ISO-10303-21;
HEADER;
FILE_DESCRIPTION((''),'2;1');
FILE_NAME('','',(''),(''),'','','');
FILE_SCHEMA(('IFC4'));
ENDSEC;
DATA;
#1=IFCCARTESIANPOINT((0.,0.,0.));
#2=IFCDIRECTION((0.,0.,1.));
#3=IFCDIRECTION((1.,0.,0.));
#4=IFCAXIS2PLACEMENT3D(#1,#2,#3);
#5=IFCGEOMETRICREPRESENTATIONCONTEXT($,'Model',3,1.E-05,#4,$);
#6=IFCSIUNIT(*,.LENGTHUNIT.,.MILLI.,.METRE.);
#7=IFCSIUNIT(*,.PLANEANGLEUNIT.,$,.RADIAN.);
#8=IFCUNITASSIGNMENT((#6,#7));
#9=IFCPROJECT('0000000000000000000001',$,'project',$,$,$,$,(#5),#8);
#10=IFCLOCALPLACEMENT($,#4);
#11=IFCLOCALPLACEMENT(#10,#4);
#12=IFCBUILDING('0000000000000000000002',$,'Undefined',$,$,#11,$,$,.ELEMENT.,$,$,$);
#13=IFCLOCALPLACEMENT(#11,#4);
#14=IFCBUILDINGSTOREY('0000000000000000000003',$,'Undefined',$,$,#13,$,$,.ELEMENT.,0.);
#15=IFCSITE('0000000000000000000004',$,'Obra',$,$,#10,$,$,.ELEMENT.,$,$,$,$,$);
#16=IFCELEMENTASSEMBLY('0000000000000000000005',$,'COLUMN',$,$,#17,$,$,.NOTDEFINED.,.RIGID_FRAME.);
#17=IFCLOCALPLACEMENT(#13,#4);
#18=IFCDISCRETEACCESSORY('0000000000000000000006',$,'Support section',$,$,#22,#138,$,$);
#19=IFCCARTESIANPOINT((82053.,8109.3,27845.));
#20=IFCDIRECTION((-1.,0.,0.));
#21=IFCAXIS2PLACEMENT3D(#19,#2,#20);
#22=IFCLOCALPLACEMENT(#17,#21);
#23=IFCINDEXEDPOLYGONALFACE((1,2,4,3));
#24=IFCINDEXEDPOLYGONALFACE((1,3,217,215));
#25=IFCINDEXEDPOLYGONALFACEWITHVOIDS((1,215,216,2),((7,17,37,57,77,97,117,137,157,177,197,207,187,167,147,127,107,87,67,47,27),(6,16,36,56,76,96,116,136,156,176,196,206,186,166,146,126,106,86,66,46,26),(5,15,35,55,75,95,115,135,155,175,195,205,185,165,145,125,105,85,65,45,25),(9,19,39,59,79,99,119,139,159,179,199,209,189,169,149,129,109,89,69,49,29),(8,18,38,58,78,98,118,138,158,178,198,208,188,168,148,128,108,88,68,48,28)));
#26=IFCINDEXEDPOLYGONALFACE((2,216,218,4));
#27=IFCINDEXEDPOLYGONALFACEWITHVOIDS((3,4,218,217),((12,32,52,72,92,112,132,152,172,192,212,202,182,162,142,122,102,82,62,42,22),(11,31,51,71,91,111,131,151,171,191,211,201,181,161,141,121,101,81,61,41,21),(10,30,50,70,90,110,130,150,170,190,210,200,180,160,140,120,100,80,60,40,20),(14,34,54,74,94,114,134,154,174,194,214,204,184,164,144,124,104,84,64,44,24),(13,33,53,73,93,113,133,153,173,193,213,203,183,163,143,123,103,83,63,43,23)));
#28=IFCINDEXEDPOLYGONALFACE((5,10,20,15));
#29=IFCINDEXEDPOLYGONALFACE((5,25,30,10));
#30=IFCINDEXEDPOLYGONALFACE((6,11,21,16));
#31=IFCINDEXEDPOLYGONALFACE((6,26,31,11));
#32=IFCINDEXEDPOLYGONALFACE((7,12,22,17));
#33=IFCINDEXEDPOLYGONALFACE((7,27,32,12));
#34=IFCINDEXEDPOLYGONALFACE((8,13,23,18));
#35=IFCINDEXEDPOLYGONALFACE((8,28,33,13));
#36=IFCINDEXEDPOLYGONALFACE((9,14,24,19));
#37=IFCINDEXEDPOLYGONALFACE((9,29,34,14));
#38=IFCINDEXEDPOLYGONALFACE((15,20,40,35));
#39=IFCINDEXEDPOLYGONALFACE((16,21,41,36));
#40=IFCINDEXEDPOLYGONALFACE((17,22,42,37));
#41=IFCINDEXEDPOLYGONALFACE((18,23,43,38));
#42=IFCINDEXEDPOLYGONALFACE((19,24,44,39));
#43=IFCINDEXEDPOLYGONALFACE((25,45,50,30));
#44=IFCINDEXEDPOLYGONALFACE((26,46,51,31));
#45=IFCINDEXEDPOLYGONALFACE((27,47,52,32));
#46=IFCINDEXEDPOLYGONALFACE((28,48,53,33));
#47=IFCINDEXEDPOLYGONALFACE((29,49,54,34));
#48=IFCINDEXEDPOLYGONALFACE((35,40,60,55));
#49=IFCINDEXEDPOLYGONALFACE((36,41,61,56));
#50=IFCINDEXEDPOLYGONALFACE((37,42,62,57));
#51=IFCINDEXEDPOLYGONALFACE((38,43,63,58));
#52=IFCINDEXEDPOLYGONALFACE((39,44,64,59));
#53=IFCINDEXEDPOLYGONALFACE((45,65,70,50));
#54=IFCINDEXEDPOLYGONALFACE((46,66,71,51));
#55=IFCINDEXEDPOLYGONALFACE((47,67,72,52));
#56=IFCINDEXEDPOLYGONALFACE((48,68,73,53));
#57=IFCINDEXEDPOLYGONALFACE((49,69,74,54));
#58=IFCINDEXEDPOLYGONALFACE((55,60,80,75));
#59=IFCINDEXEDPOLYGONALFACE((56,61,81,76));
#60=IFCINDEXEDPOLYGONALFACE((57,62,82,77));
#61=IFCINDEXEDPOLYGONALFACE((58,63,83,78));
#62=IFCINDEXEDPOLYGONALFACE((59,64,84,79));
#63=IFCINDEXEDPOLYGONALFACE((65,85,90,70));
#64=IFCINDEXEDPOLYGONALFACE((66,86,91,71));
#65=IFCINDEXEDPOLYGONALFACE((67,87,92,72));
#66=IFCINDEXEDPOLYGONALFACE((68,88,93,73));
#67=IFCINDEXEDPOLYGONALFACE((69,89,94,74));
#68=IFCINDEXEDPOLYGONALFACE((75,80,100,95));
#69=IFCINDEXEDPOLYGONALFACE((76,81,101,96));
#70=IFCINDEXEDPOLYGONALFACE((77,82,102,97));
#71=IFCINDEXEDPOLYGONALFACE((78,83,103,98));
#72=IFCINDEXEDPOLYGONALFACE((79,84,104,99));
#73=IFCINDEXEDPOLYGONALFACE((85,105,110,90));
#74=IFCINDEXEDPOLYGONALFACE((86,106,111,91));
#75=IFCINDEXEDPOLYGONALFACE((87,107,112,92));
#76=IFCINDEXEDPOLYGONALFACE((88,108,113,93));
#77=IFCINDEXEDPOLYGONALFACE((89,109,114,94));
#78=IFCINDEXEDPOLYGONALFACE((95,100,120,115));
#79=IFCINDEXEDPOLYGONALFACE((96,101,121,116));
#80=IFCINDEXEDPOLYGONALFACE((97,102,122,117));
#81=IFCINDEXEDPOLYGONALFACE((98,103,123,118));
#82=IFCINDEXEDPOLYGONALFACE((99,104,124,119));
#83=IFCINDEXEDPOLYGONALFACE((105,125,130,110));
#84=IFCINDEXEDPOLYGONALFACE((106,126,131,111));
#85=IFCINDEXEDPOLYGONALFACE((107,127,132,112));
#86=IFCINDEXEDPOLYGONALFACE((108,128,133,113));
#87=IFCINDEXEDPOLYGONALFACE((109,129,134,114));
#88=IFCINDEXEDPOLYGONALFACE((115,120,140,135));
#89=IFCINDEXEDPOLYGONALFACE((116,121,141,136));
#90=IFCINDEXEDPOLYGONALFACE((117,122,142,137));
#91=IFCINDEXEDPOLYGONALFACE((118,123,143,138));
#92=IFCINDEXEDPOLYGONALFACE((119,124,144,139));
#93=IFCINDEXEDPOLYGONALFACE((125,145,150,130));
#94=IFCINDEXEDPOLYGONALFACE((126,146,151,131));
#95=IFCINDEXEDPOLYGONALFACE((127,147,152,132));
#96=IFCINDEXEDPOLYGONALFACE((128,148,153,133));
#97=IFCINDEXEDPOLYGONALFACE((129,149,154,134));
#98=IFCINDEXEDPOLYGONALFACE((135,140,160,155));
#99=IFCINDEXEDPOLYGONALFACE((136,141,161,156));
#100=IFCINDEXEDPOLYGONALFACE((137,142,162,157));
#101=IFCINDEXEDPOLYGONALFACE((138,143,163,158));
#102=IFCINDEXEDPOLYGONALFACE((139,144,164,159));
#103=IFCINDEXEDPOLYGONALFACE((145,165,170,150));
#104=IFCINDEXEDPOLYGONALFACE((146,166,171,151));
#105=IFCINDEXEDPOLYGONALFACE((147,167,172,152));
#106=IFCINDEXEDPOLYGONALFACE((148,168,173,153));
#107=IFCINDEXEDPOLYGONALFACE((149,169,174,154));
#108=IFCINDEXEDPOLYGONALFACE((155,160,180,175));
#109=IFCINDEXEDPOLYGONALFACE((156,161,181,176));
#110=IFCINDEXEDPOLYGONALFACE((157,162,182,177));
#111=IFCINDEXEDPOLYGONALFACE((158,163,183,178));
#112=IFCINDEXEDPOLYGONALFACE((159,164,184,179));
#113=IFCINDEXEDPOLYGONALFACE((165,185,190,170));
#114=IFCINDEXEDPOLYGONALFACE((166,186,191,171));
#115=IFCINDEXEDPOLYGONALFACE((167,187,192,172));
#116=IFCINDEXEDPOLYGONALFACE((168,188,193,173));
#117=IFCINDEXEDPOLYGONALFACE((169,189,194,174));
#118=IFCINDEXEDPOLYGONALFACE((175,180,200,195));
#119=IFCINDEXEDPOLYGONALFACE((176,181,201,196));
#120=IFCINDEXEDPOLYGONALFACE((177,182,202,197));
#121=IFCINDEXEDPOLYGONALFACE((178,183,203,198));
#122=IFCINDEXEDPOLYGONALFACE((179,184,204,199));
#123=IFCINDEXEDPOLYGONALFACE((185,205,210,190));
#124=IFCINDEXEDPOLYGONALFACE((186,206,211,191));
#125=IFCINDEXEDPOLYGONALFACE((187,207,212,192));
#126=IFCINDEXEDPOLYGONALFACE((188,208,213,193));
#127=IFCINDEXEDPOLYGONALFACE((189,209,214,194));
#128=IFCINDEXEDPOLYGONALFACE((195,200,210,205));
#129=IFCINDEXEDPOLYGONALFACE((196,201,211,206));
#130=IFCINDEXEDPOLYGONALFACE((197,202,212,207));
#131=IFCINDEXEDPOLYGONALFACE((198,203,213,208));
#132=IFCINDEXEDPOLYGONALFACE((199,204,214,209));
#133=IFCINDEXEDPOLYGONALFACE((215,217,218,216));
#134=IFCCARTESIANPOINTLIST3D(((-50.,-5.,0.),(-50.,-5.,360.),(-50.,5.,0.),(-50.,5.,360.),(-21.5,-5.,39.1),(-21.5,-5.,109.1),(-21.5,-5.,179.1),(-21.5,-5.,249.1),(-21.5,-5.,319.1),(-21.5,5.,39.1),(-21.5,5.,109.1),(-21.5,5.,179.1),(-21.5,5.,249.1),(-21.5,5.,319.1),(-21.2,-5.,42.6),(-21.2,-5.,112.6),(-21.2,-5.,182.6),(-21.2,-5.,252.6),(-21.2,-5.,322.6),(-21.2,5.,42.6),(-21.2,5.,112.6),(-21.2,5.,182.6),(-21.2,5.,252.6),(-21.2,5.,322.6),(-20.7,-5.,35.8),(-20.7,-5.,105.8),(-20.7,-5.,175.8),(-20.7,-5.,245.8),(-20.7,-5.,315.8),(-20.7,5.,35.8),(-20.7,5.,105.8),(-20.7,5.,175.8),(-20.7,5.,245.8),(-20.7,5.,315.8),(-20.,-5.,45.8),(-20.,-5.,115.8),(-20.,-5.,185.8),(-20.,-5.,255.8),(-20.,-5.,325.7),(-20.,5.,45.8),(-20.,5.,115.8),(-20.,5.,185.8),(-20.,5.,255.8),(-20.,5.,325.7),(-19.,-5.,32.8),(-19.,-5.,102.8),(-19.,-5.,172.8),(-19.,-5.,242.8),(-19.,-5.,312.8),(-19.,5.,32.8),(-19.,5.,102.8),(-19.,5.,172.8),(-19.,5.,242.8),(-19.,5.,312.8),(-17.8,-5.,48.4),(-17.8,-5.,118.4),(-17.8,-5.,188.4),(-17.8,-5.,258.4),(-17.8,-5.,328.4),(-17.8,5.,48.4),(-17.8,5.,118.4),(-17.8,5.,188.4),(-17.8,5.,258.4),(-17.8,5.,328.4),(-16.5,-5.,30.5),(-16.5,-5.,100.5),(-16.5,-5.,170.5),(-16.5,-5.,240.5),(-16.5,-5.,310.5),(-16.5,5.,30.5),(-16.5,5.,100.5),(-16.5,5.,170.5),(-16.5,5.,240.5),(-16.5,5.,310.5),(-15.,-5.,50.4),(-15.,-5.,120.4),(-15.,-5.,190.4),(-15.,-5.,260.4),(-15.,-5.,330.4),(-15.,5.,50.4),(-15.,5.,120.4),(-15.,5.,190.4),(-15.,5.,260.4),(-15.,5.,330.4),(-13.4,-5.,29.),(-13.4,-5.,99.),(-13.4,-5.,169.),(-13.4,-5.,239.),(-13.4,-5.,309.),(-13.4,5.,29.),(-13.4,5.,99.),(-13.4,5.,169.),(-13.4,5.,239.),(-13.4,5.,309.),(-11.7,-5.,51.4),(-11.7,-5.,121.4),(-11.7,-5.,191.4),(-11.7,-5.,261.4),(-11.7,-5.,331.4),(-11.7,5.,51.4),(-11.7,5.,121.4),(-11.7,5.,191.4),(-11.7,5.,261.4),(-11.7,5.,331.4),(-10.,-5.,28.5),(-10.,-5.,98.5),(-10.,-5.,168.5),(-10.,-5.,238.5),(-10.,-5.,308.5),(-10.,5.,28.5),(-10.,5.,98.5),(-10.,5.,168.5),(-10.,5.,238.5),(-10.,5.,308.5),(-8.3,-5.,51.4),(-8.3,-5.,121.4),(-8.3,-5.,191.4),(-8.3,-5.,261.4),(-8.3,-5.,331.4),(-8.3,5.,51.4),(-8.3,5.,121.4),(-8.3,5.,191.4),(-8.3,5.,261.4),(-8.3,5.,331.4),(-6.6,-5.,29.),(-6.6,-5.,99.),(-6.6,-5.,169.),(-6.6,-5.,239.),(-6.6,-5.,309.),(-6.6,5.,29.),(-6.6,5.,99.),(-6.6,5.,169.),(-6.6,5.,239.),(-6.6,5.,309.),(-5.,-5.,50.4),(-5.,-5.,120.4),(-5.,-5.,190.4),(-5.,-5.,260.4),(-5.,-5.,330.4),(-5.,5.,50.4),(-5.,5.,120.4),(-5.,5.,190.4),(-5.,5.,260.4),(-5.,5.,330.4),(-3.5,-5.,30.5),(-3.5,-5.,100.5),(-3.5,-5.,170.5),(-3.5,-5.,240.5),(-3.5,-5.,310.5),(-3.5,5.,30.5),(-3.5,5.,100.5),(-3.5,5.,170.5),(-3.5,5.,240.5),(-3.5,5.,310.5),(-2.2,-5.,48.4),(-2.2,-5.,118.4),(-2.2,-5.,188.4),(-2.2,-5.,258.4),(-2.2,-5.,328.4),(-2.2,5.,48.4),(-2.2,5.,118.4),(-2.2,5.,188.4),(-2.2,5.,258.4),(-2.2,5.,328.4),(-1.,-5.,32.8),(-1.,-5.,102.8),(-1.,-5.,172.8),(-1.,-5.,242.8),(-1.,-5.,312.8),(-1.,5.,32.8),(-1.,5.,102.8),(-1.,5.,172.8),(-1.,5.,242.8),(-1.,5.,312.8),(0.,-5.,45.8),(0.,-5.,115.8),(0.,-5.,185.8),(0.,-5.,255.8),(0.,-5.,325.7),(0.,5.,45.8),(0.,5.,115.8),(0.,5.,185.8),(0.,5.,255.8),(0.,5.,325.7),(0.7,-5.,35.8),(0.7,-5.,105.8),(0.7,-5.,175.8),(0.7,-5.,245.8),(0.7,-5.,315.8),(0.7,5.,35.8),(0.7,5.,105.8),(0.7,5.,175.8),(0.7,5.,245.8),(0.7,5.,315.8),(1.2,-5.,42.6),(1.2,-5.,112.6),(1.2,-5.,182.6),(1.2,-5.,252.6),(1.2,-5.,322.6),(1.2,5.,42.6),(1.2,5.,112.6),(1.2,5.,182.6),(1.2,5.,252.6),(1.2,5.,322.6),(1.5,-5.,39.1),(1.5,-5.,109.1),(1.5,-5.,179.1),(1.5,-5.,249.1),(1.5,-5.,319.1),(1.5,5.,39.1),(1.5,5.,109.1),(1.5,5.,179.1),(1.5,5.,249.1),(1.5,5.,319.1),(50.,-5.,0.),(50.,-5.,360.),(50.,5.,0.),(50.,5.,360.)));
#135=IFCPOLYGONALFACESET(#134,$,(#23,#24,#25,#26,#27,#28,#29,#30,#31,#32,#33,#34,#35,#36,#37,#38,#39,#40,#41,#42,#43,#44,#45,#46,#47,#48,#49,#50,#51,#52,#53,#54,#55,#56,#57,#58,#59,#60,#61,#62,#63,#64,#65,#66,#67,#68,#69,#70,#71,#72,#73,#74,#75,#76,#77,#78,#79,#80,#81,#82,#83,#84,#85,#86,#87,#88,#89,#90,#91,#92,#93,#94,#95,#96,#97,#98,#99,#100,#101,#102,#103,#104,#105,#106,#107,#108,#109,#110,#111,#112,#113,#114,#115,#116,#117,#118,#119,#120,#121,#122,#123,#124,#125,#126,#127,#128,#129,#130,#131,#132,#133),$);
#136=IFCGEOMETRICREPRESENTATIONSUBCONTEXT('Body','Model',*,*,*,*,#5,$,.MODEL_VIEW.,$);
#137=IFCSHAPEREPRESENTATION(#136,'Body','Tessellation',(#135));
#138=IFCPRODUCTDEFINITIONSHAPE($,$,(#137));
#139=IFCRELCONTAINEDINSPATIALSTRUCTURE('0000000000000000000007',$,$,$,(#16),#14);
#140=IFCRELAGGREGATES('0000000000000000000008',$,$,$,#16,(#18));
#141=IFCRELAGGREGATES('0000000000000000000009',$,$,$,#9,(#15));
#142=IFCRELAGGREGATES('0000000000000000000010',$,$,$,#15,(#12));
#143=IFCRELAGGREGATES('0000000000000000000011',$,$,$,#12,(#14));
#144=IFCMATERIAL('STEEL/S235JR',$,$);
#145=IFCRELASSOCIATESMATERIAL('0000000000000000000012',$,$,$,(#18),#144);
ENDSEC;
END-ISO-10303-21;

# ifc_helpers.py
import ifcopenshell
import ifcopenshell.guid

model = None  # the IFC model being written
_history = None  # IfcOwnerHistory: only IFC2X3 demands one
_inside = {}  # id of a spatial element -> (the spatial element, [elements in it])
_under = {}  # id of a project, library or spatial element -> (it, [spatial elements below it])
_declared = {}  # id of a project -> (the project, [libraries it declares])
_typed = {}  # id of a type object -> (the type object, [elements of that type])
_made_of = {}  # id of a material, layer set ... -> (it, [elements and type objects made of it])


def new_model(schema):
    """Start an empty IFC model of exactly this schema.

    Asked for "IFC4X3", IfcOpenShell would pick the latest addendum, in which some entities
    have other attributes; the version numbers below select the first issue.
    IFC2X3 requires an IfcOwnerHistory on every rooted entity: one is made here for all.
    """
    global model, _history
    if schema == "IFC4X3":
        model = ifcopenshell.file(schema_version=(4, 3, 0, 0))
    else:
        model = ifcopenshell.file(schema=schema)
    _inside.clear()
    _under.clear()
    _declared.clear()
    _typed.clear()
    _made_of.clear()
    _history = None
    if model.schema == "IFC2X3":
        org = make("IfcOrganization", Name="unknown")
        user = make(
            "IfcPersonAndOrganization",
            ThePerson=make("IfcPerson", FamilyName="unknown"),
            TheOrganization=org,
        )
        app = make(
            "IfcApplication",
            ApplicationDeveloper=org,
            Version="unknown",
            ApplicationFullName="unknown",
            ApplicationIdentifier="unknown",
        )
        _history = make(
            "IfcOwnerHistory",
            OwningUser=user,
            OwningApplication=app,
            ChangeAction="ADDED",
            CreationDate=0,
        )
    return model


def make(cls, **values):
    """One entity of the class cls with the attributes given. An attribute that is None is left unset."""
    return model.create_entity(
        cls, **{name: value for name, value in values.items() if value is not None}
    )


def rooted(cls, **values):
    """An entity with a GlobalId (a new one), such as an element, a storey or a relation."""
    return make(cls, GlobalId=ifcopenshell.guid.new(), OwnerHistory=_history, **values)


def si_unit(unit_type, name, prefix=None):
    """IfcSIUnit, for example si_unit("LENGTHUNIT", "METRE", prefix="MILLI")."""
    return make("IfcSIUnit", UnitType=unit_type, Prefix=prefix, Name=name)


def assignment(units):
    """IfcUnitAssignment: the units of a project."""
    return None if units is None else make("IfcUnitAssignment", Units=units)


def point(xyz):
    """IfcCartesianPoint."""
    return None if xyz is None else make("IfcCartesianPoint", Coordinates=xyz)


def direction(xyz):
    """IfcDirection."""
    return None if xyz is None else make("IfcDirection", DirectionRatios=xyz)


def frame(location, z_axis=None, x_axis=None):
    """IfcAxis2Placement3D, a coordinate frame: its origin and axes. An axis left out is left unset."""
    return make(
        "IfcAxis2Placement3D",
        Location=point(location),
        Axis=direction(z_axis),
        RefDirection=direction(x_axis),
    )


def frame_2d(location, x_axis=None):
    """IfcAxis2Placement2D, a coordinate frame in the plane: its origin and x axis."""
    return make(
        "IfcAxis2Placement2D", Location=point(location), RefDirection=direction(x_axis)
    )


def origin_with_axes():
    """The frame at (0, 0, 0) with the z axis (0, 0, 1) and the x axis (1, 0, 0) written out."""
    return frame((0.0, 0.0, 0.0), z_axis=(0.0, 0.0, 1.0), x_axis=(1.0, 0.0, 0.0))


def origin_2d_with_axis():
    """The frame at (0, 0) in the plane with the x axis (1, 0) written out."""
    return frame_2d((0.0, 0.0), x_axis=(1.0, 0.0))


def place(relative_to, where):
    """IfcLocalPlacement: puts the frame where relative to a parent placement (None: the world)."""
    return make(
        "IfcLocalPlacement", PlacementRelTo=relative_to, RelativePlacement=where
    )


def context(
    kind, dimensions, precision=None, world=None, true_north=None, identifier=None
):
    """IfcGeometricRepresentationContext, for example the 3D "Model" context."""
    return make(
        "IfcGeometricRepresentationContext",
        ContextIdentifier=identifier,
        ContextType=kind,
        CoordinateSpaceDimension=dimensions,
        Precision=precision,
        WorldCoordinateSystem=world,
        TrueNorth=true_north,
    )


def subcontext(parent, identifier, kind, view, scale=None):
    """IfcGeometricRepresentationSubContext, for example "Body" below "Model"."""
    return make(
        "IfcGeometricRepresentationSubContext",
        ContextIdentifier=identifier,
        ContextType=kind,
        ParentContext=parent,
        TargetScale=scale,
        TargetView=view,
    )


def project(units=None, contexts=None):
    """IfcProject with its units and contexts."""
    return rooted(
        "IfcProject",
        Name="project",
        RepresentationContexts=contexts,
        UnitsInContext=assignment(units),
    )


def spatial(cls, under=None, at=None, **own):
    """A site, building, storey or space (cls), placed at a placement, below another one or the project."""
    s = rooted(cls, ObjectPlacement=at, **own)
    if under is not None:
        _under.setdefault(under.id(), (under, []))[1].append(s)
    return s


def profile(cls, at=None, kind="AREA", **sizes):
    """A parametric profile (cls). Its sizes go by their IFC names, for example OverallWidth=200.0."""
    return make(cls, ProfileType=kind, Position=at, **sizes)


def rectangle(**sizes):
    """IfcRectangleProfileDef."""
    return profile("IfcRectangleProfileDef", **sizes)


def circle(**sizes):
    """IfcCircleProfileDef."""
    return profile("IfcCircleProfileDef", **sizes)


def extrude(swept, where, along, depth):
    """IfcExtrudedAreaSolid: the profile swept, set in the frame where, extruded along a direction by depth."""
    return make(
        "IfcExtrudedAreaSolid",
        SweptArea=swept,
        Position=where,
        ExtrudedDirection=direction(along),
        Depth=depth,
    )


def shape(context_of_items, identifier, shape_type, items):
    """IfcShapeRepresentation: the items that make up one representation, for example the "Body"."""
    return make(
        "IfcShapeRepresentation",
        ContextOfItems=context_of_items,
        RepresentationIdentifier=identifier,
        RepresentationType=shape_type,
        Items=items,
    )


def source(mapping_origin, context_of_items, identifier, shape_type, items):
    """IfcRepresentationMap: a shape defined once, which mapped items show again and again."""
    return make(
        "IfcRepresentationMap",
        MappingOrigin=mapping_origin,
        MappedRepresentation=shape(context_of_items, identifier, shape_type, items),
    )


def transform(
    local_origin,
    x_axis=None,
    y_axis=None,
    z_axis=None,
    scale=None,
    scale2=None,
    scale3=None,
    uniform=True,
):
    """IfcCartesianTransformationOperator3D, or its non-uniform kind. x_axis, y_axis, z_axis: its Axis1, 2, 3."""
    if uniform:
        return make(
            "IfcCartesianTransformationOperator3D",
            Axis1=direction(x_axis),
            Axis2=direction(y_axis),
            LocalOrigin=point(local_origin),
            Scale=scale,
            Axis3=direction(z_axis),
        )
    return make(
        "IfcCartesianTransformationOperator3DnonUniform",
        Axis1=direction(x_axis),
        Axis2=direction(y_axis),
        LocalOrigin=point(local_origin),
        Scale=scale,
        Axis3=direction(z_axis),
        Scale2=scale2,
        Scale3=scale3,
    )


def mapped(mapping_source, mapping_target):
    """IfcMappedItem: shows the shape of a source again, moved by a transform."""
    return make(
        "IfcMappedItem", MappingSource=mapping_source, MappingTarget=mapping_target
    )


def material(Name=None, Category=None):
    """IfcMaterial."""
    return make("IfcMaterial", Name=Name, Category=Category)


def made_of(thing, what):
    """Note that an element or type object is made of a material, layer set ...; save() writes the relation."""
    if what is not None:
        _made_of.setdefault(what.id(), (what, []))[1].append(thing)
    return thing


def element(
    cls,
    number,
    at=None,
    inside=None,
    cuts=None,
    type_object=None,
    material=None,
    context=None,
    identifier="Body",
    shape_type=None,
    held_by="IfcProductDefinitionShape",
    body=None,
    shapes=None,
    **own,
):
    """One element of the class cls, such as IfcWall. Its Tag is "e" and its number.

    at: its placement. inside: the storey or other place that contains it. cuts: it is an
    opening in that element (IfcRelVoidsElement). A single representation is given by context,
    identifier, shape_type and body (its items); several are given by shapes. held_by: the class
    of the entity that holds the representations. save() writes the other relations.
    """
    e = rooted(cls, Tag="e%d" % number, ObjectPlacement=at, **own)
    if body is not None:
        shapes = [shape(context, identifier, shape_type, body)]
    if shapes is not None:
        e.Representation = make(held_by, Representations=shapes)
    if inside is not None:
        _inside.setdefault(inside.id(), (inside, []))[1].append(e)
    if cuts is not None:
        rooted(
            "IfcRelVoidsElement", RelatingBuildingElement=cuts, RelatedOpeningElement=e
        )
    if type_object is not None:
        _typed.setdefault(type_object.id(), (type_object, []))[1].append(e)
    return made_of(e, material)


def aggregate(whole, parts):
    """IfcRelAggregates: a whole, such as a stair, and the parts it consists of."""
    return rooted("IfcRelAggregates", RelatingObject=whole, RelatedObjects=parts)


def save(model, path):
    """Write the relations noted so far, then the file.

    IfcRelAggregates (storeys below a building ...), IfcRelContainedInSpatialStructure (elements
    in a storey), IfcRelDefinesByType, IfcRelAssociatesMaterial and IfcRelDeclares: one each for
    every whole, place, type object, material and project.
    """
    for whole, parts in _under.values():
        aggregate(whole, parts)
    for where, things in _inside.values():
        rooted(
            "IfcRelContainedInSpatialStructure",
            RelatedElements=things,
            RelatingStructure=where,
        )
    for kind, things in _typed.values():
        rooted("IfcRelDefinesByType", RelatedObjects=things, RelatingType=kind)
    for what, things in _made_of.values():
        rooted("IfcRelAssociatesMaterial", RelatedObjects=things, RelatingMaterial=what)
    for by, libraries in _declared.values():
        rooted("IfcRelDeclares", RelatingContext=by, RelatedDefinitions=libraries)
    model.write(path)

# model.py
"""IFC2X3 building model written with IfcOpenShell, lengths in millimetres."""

from ifc_helpers import new_model, si_unit, frame, origin_with_axes, origin_2d_with_axis, place, context, subcontext, project, spatial, rectangle, circle, extrude, source, transform, mapped, material, element, aggregate, save


model = new_model("IFC2X3")

# Units and contexts
model_context = context("Model", 3, precision=1e-05, world=origin_with_axes())
body_context = subcontext(model_context, "Body", "Model", "MODEL_VIEW")
ifc_project = project(units=[si_unit("LENGTHUNIT", "METRE", prefix="MILLI"), si_unit("PLANEANGLEUNIT", "RADIAN")], contexts=[model_context])

# Site, building, storey
site_placement = place(None, origin_with_axes())
site = spatial("IfcSite", under=ifc_project, at=site_placement, Name="Obra", CompositionType="ELEMENT")
building_placement = place(site_placement, origin_with_axes())
building = spatial("IfcBuilding", under=site, at=building_placement, Name="Undefined", CompositionType="ELEMENT")
storey_placement = place(building_placement, origin_with_axes())
storey = spatial("IfcBuildingStorey", under=building, at=storey_placement, Name="Undefined", CompositionType="ELEMENT", Elevation=0.0)

# Shared definitions
ifc_material = material(Name="STEEL/S235JR")

# Element assembly, discrete accessory, opening
assembly_1_placement = place(storey_placement, origin_with_axes())
assembly_1 = element("IfcElementAssembly", 1, at=assembly_1_placement, inside=storey, Name="COLUMN", AssemblyPlace="NOTDEFINED", PredefinedType="RIGID_FRAME")
discrete_accessory_1_placement = place(assembly_1_placement, frame((82053.0, 8109.3, 27845.0), z_axis=(0.0, 0.0, 1.0), x_axis=(-1.0, 0.0, 0.0)))
discrete_accessory_1 = element("IfcDiscreteAccessory", 2, at=discrete_accessory_1_placement, material=ifc_material, Name="Support section", context=body_context, shape_type="SweptSolid", body=[
    extrude(rectangle(XDim=10.0, YDim=100.0, at=origin_2d_with_axis()), frame((0.0, 0.0, 360.0), z_axis=(0.0, 0.0, -1.0), x_axis=(0.0, 1.0, 0.0)), (0.0, 0.0, 1.0), 360.0),
])
shared_shape_1 = source(origin_with_axes(), body_context, "Body", "SweptSolid", [
    extrude(circle(Radius=11.5, at=origin_2d_with_axis()), frame((0.0, -14.8, 0.0), z_axis=(0.0, 1.0, 0.0), x_axis=(1.0, 0.0, 0.0)), (0.0, 0.0, 1.0), 10.2),
])
opening_1_placement = place(assembly_1_placement, frame((82023.0, 8119.0, 28250.0), z_axis=(1.0, 0.0, 0.0), x_axis=(0.0, 0.0, -1.0)))
element("IfcOpeningElement", 3, at=opening_1_placement, cuts=discrete_accessory_1, ObjectType="Opening", context=body_context, shape_type="MappedRepresentation", body=[
    mapped(shared_shape_1, transform((85.0, 0.0, 40.0))),
    mapped(shared_shape_1, transform((155.0, 0.0, 40.0))),
    mapped(shared_shape_1, transform((225.0, 0.0, 40.0))),
    mapped(shared_shape_1, transform((295.0, 0.0, 40.0))),
    mapped(shared_shape_1, transform((365.0, 0.0, 40.0))),
])
aggregate(assembly_1, [discrete_accessory_1])

save(model, "model.ifc")
